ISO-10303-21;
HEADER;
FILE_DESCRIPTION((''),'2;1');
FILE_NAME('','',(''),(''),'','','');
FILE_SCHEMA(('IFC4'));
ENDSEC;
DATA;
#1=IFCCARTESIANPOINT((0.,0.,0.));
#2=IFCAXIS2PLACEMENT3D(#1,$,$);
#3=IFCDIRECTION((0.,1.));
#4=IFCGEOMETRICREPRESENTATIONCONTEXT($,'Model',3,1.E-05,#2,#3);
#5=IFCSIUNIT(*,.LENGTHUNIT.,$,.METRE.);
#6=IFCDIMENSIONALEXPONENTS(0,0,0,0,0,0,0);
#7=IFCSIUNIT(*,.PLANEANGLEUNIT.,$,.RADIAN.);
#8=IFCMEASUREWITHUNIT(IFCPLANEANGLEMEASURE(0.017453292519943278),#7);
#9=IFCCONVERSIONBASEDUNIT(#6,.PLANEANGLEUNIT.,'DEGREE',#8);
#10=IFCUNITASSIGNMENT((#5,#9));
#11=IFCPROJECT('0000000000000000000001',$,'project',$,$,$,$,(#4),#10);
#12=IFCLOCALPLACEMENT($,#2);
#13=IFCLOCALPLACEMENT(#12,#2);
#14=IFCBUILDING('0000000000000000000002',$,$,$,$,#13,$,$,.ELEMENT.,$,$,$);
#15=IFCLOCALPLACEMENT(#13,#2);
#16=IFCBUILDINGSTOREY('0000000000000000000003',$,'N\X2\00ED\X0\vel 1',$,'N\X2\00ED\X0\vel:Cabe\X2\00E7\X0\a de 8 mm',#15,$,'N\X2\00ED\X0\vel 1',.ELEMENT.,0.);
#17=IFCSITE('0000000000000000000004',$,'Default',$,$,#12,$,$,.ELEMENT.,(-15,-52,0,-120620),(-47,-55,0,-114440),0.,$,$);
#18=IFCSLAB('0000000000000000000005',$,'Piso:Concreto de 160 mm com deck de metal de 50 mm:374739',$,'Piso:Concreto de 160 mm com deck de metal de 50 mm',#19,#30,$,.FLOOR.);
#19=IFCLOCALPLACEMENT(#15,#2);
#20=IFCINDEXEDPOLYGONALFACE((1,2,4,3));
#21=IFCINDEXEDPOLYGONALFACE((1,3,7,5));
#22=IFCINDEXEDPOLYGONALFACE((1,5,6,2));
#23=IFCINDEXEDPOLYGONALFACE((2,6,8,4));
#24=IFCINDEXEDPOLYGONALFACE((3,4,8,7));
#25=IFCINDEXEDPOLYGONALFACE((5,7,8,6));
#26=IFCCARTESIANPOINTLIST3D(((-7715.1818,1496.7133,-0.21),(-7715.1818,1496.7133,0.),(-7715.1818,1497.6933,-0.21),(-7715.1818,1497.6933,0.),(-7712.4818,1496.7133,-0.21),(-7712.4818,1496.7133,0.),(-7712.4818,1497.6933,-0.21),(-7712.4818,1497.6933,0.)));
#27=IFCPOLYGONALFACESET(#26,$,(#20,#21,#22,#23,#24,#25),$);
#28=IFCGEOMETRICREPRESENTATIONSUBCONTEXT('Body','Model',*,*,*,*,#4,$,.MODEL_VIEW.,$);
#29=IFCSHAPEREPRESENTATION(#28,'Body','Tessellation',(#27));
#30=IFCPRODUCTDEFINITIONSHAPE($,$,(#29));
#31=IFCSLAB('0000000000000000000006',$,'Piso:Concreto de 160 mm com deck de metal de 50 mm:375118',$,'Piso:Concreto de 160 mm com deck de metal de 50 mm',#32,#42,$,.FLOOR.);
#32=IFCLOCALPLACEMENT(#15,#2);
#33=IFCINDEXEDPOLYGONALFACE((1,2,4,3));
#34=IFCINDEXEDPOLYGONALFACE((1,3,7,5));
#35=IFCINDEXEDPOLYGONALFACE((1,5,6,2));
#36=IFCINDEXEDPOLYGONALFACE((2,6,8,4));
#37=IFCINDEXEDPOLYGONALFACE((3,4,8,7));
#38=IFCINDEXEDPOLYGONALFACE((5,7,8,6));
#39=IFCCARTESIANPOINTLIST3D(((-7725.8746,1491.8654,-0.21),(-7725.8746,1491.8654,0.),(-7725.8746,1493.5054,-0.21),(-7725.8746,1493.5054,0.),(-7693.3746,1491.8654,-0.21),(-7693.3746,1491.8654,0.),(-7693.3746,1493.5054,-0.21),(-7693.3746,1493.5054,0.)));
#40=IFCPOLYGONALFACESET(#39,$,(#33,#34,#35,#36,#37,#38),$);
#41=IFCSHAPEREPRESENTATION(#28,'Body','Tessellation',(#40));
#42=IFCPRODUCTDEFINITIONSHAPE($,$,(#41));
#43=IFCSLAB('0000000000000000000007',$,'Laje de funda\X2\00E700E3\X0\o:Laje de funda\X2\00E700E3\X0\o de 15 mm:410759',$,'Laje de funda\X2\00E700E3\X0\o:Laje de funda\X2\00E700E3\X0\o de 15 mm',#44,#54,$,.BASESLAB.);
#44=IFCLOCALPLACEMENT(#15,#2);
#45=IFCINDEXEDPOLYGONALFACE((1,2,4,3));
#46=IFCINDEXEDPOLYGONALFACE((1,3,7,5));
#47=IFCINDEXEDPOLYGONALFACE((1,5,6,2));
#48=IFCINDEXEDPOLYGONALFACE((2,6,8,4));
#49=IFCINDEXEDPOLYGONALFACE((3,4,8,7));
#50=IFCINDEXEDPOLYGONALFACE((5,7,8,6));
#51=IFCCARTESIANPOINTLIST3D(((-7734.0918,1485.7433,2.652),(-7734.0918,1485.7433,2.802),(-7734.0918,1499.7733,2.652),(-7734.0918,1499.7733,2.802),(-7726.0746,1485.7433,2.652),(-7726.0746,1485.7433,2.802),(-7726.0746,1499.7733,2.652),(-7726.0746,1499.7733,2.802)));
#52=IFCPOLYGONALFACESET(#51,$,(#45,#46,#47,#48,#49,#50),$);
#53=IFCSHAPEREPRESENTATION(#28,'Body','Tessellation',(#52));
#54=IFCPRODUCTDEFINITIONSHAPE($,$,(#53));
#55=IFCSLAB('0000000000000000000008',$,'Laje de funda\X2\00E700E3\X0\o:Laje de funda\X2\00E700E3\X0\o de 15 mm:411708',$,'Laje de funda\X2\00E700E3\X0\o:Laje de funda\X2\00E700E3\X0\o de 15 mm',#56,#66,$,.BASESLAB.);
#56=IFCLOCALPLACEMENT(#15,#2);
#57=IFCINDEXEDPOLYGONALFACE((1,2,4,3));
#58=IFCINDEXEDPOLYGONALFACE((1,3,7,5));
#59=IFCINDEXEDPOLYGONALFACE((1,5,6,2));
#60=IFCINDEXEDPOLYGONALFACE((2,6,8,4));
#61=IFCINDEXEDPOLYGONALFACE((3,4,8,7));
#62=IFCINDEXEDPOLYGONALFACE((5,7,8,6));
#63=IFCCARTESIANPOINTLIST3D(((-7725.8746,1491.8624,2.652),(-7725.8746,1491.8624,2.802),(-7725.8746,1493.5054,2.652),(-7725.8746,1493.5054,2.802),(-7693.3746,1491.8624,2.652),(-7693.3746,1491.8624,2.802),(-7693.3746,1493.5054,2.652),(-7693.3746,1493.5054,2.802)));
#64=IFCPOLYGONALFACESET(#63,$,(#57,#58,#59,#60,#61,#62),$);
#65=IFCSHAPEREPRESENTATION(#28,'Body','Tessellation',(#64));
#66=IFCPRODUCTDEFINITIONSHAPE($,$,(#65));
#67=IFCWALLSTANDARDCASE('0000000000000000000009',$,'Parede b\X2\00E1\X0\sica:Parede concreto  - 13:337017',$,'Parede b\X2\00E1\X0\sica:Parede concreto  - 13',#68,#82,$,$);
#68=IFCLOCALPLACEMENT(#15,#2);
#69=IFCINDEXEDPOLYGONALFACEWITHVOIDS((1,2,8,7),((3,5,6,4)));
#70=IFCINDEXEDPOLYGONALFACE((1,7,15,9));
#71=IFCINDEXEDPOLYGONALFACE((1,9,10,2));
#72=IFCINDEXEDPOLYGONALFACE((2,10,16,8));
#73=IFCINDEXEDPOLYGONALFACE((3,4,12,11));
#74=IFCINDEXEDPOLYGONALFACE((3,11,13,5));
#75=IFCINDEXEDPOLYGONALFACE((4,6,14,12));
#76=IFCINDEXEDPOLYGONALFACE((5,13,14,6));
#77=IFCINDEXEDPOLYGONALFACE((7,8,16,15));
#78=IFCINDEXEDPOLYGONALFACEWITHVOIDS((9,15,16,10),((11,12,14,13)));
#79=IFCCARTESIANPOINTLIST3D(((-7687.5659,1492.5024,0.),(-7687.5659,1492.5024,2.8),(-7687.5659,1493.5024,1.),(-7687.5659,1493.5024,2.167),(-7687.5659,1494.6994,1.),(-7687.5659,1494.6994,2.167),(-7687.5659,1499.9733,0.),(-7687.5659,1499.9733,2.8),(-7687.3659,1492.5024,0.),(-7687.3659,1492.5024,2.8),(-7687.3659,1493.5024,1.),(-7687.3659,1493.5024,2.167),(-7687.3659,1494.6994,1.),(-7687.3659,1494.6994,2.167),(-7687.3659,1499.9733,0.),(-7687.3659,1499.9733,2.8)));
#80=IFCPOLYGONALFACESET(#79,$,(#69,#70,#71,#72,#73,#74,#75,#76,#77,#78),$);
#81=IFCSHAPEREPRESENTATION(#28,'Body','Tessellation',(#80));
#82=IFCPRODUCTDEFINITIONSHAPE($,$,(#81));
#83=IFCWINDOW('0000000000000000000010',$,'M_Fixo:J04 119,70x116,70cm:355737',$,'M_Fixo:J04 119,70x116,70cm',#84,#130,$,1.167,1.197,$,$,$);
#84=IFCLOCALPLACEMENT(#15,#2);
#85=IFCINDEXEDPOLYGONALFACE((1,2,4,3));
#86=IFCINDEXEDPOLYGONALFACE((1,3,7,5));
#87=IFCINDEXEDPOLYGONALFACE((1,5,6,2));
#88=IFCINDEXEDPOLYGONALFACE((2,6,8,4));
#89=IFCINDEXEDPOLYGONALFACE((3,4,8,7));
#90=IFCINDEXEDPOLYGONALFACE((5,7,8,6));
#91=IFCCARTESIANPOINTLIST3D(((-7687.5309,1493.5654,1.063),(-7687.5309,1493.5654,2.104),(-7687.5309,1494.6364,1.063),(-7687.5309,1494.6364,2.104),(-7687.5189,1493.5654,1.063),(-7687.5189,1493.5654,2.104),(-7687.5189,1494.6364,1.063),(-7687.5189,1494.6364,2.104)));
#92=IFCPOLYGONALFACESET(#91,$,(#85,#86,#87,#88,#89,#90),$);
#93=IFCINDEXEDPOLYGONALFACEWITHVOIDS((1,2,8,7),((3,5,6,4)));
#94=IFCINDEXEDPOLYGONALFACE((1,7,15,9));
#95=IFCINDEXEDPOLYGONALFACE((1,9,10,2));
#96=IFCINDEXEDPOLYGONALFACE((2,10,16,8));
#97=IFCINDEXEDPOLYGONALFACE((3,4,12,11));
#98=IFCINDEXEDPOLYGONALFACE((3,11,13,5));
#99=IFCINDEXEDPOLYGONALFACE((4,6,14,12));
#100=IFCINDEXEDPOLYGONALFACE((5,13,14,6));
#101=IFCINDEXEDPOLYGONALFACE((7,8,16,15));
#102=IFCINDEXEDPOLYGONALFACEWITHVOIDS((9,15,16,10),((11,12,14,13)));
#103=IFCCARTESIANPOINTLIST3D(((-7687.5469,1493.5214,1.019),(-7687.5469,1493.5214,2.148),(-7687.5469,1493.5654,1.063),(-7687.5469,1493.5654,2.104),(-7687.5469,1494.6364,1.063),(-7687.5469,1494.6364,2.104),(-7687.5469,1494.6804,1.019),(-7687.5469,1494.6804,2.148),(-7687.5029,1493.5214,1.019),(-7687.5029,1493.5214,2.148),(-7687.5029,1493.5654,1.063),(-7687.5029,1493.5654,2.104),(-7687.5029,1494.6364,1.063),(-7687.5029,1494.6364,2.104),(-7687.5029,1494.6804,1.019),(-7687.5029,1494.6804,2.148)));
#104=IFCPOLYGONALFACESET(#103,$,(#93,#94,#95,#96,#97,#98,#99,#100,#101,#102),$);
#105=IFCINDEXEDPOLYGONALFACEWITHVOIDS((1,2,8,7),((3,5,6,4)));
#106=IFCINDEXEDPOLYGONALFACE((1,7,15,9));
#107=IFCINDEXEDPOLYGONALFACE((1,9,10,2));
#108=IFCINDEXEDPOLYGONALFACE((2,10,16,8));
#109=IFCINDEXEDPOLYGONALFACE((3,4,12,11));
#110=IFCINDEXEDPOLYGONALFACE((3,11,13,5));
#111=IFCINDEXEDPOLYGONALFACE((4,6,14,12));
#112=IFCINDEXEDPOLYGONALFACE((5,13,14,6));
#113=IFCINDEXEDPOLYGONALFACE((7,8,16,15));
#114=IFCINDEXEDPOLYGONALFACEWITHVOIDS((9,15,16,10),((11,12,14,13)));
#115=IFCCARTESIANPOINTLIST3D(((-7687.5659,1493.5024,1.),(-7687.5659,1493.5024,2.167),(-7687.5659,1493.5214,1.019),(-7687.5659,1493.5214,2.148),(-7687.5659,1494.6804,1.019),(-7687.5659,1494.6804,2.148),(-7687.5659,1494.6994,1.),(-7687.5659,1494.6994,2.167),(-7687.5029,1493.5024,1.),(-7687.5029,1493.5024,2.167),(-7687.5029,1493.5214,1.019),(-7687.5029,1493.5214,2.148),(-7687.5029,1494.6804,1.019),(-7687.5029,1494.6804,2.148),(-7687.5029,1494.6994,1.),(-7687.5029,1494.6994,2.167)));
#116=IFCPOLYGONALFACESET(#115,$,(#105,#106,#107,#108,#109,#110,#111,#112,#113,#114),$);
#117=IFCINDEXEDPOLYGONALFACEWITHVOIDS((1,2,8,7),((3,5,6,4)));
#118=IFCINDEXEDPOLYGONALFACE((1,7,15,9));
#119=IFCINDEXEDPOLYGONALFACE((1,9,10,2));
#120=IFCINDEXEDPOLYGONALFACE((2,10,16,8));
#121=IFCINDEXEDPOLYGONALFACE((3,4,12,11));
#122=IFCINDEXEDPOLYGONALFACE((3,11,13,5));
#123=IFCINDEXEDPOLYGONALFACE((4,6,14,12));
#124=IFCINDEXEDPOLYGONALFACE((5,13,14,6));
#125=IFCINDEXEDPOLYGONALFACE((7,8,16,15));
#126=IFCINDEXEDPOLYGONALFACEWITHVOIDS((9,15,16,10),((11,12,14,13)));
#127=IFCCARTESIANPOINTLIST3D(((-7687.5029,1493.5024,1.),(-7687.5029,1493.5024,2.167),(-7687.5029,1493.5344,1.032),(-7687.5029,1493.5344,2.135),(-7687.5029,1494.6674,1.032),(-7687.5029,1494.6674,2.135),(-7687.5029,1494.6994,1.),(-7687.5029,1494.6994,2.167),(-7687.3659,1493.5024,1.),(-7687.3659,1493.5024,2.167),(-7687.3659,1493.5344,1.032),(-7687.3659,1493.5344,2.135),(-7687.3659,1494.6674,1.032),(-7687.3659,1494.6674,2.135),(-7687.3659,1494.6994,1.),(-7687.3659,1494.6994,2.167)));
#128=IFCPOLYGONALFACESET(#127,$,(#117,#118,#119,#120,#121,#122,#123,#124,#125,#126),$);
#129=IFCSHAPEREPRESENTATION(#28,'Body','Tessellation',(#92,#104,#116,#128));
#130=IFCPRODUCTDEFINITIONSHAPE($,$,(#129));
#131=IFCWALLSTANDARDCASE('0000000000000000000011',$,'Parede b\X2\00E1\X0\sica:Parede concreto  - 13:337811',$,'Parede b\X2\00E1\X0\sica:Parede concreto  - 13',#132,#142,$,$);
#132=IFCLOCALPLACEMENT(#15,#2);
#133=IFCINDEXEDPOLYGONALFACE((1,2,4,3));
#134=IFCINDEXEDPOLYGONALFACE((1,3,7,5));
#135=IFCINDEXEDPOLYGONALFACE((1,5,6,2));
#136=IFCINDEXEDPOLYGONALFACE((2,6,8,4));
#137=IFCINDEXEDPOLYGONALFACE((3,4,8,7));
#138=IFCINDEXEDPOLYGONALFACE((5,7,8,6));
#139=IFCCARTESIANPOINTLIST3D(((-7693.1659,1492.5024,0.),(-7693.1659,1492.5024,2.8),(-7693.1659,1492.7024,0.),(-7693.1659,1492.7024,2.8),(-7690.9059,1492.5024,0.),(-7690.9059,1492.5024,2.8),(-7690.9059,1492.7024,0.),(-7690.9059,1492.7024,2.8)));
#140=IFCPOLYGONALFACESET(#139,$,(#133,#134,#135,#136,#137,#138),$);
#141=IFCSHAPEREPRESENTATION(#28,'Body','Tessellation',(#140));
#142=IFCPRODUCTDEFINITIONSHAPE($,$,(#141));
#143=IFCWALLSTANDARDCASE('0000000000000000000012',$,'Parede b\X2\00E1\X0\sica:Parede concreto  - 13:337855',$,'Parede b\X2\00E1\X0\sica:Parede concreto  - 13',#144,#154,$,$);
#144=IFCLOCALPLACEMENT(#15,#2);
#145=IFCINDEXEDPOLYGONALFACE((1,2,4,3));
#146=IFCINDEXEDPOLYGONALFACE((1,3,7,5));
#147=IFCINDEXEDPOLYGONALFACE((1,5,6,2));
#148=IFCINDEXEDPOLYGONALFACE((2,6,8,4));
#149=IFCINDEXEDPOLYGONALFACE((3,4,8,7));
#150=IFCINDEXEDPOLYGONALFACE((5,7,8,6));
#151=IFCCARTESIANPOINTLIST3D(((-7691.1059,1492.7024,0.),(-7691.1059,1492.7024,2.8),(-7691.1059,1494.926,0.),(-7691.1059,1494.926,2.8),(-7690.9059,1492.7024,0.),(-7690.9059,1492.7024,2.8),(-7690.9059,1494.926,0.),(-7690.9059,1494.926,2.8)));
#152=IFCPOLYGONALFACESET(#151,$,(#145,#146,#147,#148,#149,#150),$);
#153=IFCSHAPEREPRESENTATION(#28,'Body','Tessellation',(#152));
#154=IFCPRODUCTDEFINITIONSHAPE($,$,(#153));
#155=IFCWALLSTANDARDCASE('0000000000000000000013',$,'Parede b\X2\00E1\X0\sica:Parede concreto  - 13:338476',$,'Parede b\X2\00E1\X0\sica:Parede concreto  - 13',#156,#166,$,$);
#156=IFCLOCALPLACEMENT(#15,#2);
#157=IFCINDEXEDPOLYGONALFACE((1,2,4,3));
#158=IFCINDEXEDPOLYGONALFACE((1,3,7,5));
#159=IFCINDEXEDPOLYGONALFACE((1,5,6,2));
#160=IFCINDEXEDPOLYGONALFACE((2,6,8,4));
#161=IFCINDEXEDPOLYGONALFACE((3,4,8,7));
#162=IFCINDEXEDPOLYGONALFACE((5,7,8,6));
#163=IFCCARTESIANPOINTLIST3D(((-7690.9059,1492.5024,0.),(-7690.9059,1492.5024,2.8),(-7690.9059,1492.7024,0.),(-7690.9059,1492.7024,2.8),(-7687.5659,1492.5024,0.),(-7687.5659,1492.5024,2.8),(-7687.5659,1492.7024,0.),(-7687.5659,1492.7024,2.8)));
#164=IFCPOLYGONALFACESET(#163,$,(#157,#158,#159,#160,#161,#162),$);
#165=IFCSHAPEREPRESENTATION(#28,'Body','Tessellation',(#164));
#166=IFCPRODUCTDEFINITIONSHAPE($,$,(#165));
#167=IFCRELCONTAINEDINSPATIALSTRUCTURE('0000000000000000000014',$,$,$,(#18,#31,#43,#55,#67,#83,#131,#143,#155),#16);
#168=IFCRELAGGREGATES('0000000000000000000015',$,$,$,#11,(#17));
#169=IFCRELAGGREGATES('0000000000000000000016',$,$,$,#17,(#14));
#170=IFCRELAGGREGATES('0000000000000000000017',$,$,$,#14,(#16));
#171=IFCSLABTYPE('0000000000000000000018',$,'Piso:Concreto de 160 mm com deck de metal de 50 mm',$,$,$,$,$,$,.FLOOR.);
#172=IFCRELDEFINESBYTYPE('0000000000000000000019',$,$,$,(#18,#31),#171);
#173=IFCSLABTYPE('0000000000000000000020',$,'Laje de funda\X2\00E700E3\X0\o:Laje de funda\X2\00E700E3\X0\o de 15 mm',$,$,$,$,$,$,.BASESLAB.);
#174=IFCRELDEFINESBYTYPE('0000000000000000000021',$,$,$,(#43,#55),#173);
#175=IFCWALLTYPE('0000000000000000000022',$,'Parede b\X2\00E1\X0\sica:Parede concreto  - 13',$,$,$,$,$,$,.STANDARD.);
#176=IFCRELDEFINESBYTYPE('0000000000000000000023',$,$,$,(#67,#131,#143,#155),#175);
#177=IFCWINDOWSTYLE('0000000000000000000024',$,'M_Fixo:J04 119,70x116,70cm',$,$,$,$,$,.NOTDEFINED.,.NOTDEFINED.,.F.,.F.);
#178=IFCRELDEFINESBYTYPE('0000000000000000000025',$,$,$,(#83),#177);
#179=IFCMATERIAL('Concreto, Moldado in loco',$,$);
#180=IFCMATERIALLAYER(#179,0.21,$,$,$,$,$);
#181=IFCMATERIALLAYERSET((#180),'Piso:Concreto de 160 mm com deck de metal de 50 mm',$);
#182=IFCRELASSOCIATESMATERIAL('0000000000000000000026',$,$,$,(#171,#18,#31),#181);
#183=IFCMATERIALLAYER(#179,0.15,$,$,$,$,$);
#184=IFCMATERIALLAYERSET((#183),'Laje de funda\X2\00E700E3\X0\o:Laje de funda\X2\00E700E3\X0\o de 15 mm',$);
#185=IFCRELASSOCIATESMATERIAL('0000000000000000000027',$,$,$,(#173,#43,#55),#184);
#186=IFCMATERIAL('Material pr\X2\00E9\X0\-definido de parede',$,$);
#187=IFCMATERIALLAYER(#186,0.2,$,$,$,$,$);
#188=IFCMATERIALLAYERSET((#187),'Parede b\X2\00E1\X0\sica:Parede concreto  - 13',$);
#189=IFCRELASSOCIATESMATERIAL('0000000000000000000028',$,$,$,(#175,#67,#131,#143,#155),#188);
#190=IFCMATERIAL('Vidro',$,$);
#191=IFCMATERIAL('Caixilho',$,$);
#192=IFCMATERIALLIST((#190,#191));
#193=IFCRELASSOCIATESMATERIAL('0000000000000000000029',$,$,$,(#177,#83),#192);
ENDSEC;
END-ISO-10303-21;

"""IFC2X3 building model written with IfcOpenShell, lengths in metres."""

from ifc_helpers import new_model, entity, si_unit, converted_unit, direction, frame, frame_2d, origin, origin_2d_with_axis, place, context, subcontext, project, spatial, polyline, rectangle, outline, extrude, source, transform, mapped, material, material_list, layer, layer_set, layer_usage, type_object, type_shapes, element, fill, save


model = new_model("IFC2X3")

# Units and contexts
model_context = context("Model", 3, precision=1e-05, world=origin(), true_north=direction((0.0, 1.0)))
body_context = subcontext(model_context, "Body", "Model", "MODEL_VIEW")
ifc_project = project(units=[si_unit("LENGTHUNIT", "METRE"), converted_unit("PLANEANGLEUNIT", "DEGREE", entity("IfcPlaneAngleMeasure", 0.017453292519943278), si_unit("PLANEANGLEUNIT", "RADIAN"), dimensions=[0, 0, 0, 0, 0, 0, 0])], contexts=[model_context])

# Site, building, storey
site_placement = place(None, origin())
site = spatial("IfcSite", under=ifc_project, at=site_placement, Name="Default", CompositionType="ELEMENT", RefLatitude=(-15, -52, 0, -120620), RefLongitude=(-47, -55, 0, -114440), RefElevation=0.0)
building_placement = place(site_placement, origin())
building = spatial("IfcBuilding", under=site, at=building_placement, CompositionType="ELEMENT")
storey_placement = place(building_placement, origin())
storey = spatial("IfcBuildingStorey", under=building, at=storey_placement, Name="Nível 1", ObjectType="Nível:Cabeça de 8 mm", LongName="Nível 1", CompositionType="ELEMENT", Elevation=0.0)

# Slabs
ifc_material_1 = material(Name="Concreto, Moldado in loco")
ifc_layer_1 = layer(ifc_material_1, 0.21)
ifc_layer_set_1 = layer_set([ifc_layer_1], Name="Piso:Concreto de 160 mm com deck de metal de 50 mm")
ifc_layer_usage_1 = layer_usage(ifc_layer_set_1, "AXIS3", "POSITIVE", 0.0)
slab_type_1 = type_object("IfcSlabType", Name="Piso:Concreto de 160 mm com deck de metal de 50 mm", PredefinedType="FLOOR", material=ifc_layer_set_1)
slab_1_placement = place(storey_placement, origin())
element("IfcSlab", 1, at=slab_1_placement, inside=storey, type_object=slab_type_1, material=ifc_layer_usage_1, Name="Piso:Concreto de 160 mm com deck de metal de 50 mm:374739", ObjectType="Piso:Concreto de 160 mm com deck de metal de 50 mm", PredefinedType="FLOOR", context=body_context, shape_type="SweptSolid", body=[
    extrude(rectangle(XDim=0.98, YDim=2.7, at=frame_2d((0.0, 0.0), x_axis=(1.0, 0.0))), frame((-7713.8318, 1497.2033, 0.0), z_axis=(0.0, 0.0, -1.0), x_axis=(0.0, 1.0, 0.0)), (0.0, 0.0, 1.0), 0.21),
])
ifc_layer_usage_2 = layer_usage(ifc_layer_set_1, "AXIS3", "POSITIVE", 0.0)
slab_2_placement = place(storey_placement, origin())
element("IfcSlab", 2, at=slab_2_placement, inside=storey, type_object=slab_type_1, material=ifc_layer_usage_2, Name="Piso:Concreto de 160 mm com deck de metal de 50 mm:375118", ObjectType="Piso:Concreto de 160 mm com deck de metal de 50 mm", PredefinedType="FLOOR", context=body_context, shape_type="SweptSolid", body=[
    extrude(rectangle(XDim=1.64, YDim=32.5, at=frame_2d((0.0, 0.0), x_axis=(1.0, 0.0))), frame((-7709.6246, 1492.6854, 0.0), z_axis=(0.0, 0.0, -1.0), x_axis=(0.0, 1.0, 0.0)), (0.0, 0.0, 1.0), 0.21),
])
ifc_layer_2 = layer(ifc_material_1, 0.15)
ifc_layer_set_2 = layer_set([ifc_layer_2], Name="Laje de fundação:Laje de fundação de 15 mm")
ifc_layer_usage_3 = layer_usage(ifc_layer_set_2, "AXIS3", "POSITIVE", 0.0)
slab_type_2 = type_object("IfcSlabType", Name="Laje de fundação:Laje de fundação de 15 mm", PredefinedType="BASESLAB", material=ifc_layer_set_2)
slab_3_placement = place(storey_placement, origin())
element("IfcSlab", 3, at=slab_3_placement, inside=storey, type_object=slab_type_2, material=ifc_layer_usage_3, Name="Laje de fundação:Laje de fundação de 15 mm:410759", ObjectType="Laje de fundação:Laje de fundação de 15 mm", PredefinedType="BASESLAB", context=body_context, shape_type="SweptSolid", body=[
    extrude(rectangle(XDim=14.03, YDim=8.0172, at=frame_2d((0.0, 0.0), x_axis=(1.0, 0.0))), frame((-7730.0832, 1492.7583, 2.802), z_axis=(0.0, 0.0, -1.0), x_axis=(0.0, 1.0, 0.0)), (0.0, 0.0, 1.0), 0.15),
])
ifc_layer_usage_4 = layer_usage(ifc_layer_set_2, "AXIS3", "POSITIVE", 0.0)
slab_4_placement = place(storey_placement, origin())
element("IfcSlab", 4, at=slab_4_placement, inside=storey, type_object=slab_type_2, material=ifc_layer_usage_4, Name="Laje de fundação:Laje de fundação de 15 mm:411708", ObjectType="Laje de fundação:Laje de fundação de 15 mm", PredefinedType="BASESLAB", context=body_context, shape_type="SweptSolid", body=[
    extrude(rectangle(XDim=32.5, YDim=1.6429, at=origin_2d_with_axis()), frame((-7709.6246, 1492.6839, 2.802), z_axis=(0.0, 0.0, -1.0), x_axis=(1.0, 0.0, 0.0)), (0.0, 0.0, 1.0), 0.15),
])

# Wall, opening, window
ifc_material_2 = material(Name="Material pré-definido de parede")
ifc_layer_3 = layer(ifc_material_2, 0.2)
ifc_layer_set_3 = layer_set([ifc_layer_3], Name="Parede básica:Parede concreto  - 13")
ifc_layer_usage_5 = layer_usage(ifc_layer_set_3, "AXIS2", "NEGATIVE", 0.1)
wall_type = type_object("IfcWallType", Name="Parede básica:Parede concreto  - 13", PredefinedType="STANDARD", material=ifc_layer_set_3)
wall_1_placement = place(storey_placement, frame((-7687.4659, 1499.9733, 0.0), z_axis=(0.0, 0.0, 1.0), x_axis=(0.0, -1.0, 0.0)))
wall_1 = element("IfcWallStandardCase", 5, at=wall_1_placement, inside=storey, type_object=wall_type, material=ifc_layer_usage_5, Name="Parede básica:Parede concreto  - 13:337017", ObjectType="Parede básica:Parede concreto  - 13", context=body_context, shape_type="SweptSolid", body=[
    extrude(rectangle(XDim=7.4709, YDim=0.2, at=frame_2d((3.7354, 0.0), x_axis=(-1.0, 0.0))), origin(), (0.0, 0.0, 1.0), 2.8),
])
opening_1_placement = place(wall_1_placement, frame((6.4709, 0.1, 1.0)))
opening_1 = element("IfcOpeningElement", 6, at=opening_1_placement, cuts=wall_1, ObjectType="Opening", context=body_context, shape_type="SweptSolid", body=[
    extrude(rectangle(XDim=1.167, YDim=1.197, at=frame_2d((0.5835, 0.5985), x_axis=(1.0, 0.0))), frame((0.0, 0.0, 0.0), z_axis=(0.0, -1.0, 0.0), x_axis=(0.0, 0.0, 1.0)), (0.0, 0.0, 1.0), 0.2),
])
ifc_material_3 = material(Name="Vidro")
ifc_material_4 = material(Name="Caixilho")
ifc_material_list = material_list([ifc_material_3, ifc_material_4])
window_style = type_object("IfcWindowStyle", Name="M_Fixo:J04 119,70x116,70cm", ConstructionType="NOTDEFINED", OperationType="NOTDEFINED", ParameterTakesPrecedence=False, Sizeable=False, material=ifc_material_list)
shared_shape = source(origin(), body_context, "Body", "SweptSolid", [
    extrude(rectangle(XDim=0.012, YDim=1.071, at=frame_2d((0.0, 0.0), x_axis=(1.0, 0.0))), frame((0.5985, 0.159, 0.063), z_axis=(0.0, 0.0, 1.0), x_axis=(0.0, -1.0, 0.0)), (0.0, 0.0, 1.0), 1.041),
    extrude(outline(polyline([(-0.5795, -0.5645), (0.5795, -0.5645), (0.5795, 0.5645), (-0.5795, 0.5645), (-0.5795, -0.5645)]), holes=[polyline([(-0.5355, -0.5205), (-0.5355, 0.5205), (0.5355, 0.5205), (0.5355, -0.5205), (-0.5355, -0.5205)])]), frame((0.5985, 0.137, 0.5835), z_axis=(0.0, 1.0, 0.0), x_axis=(1.0, 0.0, 0.0)), (0.0, 0.0, 1.0), 0.044),
    extrude(outline(polyline([(-0.5985, -0.5835), (0.5985, -0.5835), (0.5985, 0.5835), (-0.5985, 0.5835), (-0.5985, -0.5835)]), holes=[polyline([(-0.5795, -0.5645), (-0.5795, 0.5645), (0.5795, 0.5645), (0.5795, -0.5645), (-0.5795, -0.5645)])]), frame((0.5985, 0.137, 0.5835), z_axis=(0.0, 1.0, 0.0), x_axis=(1.0, 0.0, 0.0)), (0.0, 0.0, 1.0), 0.063),
    extrude(outline(polyline([(-0.5985, -0.5835), (0.5985, -0.5835), (0.5985, 0.5835), (-0.5985, 0.5835), (-0.5985, -0.5835)]), holes=[polyline([(-0.5665, -0.5515), (-0.5665, 0.5515), (0.5665, 0.5515), (0.5665, -0.5515), (-0.5665, -0.5515)])]), frame((0.5985, 0.0, 0.5835), z_axis=(0.0, 1.0, 0.0), x_axis=(1.0, 0.0, 0.0)), (0.0, 0.0, 1.0), 0.137),
])
type_shapes(window_style, [shared_shape])
window_1_placement = place(opening_1_placement, frame((0.0, 0.0, 0.0), z_axis=(0.0, 0.0, 1.0), x_axis=(-1.0, 0.0, 0.0)))
window_1 = element("IfcWindow", 7, at=window_1_placement, inside=storey, type_object=window_style, material=ifc_material_list, Name="M_Fixo:J04 119,70x116,70cm:355737", ObjectType="M_Fixo:J04 119,70x116,70cm", OverallHeight=1.167, OverallWidth=1.197, context=body_context, shape_type="MappedRepresentation", body=[
    mapped(shared_shape, transform((0.0, 0.0, 0.0), scale=1.0)),
])
fill(opening_1, window_1)

# Walls
ifc_layer_usage_6 = layer_usage(ifc_layer_set_3, "AXIS2", "NEGATIVE", 0.1)
wall_2_placement = place(storey_placement, frame((-7693.1659, 1492.6024, 0.0)))
element("IfcWallStandardCase", 8, at=wall_2_placement, inside=storey, type_object=wall_type, material=ifc_layer_usage_6, Name="Parede básica:Parede concreto  - 13:337811", ObjectType="Parede básica:Parede concreto  - 13", context=body_context, shape_type="SweptSolid", body=[
    extrude(rectangle(XDim=2.26, YDim=0.2, at=frame_2d((1.13, 0.0), x_axis=(-1.0, 0.0))), origin(), (0.0, 0.0, 1.0), 2.8),
])
ifc_layer_usage_7 = layer_usage(ifc_layer_set_3, "AXIS2", "NEGATIVE", 0.1)
wall_3_placement = place(storey_placement, frame((-7691.0059, 1492.7024, 0.0), z_axis=(0.0, 0.0, 1.0), x_axis=(0.0, 1.0, 0.0)))
element("IfcWallStandardCase", 9, at=wall_3_placement, inside=storey, type_object=wall_type, material=ifc_layer_usage_7, Name="Parede básica:Parede concreto  - 13:337855", ObjectType="Parede básica:Parede concreto  - 13", context=body_context, shape_type="SweptSolid", body=[
    extrude(rectangle(XDim=2.2236, YDim=0.2, at=frame_2d((1.1118, 0.0), x_axis=(-1.0, 0.0))), origin(), (0.0, 0.0, 1.0), 2.8),
])
ifc_layer_usage_8 = layer_usage(ifc_layer_set_3, "AXIS2", "POSITIVE", -0.1)
wall_4_placement = place(storey_placement, frame((-7687.5659, 1492.6024, 0.0), z_axis=(0.0, 0.0, 1.0), x_axis=(-1.0, 0.0, 0.0)))
element("IfcWallStandardCase", 10, at=wall_4_placement, inside=storey, type_object=wall_type, material=ifc_layer_usage_8, Name="Parede básica:Parede concreto  - 13:338476", ObjectType="Parede básica:Parede concreto  - 13", context=body_context, shape_type="SweptSolid", body=[
    extrude(rectangle(XDim=3.34, YDim=0.2, at=frame_2d((1.67, 0.0), x_axis=(-1.0, 0.0))), origin(), (0.0, 0.0, 1.0), 2.8),
])

save(model, "model.ifc")
